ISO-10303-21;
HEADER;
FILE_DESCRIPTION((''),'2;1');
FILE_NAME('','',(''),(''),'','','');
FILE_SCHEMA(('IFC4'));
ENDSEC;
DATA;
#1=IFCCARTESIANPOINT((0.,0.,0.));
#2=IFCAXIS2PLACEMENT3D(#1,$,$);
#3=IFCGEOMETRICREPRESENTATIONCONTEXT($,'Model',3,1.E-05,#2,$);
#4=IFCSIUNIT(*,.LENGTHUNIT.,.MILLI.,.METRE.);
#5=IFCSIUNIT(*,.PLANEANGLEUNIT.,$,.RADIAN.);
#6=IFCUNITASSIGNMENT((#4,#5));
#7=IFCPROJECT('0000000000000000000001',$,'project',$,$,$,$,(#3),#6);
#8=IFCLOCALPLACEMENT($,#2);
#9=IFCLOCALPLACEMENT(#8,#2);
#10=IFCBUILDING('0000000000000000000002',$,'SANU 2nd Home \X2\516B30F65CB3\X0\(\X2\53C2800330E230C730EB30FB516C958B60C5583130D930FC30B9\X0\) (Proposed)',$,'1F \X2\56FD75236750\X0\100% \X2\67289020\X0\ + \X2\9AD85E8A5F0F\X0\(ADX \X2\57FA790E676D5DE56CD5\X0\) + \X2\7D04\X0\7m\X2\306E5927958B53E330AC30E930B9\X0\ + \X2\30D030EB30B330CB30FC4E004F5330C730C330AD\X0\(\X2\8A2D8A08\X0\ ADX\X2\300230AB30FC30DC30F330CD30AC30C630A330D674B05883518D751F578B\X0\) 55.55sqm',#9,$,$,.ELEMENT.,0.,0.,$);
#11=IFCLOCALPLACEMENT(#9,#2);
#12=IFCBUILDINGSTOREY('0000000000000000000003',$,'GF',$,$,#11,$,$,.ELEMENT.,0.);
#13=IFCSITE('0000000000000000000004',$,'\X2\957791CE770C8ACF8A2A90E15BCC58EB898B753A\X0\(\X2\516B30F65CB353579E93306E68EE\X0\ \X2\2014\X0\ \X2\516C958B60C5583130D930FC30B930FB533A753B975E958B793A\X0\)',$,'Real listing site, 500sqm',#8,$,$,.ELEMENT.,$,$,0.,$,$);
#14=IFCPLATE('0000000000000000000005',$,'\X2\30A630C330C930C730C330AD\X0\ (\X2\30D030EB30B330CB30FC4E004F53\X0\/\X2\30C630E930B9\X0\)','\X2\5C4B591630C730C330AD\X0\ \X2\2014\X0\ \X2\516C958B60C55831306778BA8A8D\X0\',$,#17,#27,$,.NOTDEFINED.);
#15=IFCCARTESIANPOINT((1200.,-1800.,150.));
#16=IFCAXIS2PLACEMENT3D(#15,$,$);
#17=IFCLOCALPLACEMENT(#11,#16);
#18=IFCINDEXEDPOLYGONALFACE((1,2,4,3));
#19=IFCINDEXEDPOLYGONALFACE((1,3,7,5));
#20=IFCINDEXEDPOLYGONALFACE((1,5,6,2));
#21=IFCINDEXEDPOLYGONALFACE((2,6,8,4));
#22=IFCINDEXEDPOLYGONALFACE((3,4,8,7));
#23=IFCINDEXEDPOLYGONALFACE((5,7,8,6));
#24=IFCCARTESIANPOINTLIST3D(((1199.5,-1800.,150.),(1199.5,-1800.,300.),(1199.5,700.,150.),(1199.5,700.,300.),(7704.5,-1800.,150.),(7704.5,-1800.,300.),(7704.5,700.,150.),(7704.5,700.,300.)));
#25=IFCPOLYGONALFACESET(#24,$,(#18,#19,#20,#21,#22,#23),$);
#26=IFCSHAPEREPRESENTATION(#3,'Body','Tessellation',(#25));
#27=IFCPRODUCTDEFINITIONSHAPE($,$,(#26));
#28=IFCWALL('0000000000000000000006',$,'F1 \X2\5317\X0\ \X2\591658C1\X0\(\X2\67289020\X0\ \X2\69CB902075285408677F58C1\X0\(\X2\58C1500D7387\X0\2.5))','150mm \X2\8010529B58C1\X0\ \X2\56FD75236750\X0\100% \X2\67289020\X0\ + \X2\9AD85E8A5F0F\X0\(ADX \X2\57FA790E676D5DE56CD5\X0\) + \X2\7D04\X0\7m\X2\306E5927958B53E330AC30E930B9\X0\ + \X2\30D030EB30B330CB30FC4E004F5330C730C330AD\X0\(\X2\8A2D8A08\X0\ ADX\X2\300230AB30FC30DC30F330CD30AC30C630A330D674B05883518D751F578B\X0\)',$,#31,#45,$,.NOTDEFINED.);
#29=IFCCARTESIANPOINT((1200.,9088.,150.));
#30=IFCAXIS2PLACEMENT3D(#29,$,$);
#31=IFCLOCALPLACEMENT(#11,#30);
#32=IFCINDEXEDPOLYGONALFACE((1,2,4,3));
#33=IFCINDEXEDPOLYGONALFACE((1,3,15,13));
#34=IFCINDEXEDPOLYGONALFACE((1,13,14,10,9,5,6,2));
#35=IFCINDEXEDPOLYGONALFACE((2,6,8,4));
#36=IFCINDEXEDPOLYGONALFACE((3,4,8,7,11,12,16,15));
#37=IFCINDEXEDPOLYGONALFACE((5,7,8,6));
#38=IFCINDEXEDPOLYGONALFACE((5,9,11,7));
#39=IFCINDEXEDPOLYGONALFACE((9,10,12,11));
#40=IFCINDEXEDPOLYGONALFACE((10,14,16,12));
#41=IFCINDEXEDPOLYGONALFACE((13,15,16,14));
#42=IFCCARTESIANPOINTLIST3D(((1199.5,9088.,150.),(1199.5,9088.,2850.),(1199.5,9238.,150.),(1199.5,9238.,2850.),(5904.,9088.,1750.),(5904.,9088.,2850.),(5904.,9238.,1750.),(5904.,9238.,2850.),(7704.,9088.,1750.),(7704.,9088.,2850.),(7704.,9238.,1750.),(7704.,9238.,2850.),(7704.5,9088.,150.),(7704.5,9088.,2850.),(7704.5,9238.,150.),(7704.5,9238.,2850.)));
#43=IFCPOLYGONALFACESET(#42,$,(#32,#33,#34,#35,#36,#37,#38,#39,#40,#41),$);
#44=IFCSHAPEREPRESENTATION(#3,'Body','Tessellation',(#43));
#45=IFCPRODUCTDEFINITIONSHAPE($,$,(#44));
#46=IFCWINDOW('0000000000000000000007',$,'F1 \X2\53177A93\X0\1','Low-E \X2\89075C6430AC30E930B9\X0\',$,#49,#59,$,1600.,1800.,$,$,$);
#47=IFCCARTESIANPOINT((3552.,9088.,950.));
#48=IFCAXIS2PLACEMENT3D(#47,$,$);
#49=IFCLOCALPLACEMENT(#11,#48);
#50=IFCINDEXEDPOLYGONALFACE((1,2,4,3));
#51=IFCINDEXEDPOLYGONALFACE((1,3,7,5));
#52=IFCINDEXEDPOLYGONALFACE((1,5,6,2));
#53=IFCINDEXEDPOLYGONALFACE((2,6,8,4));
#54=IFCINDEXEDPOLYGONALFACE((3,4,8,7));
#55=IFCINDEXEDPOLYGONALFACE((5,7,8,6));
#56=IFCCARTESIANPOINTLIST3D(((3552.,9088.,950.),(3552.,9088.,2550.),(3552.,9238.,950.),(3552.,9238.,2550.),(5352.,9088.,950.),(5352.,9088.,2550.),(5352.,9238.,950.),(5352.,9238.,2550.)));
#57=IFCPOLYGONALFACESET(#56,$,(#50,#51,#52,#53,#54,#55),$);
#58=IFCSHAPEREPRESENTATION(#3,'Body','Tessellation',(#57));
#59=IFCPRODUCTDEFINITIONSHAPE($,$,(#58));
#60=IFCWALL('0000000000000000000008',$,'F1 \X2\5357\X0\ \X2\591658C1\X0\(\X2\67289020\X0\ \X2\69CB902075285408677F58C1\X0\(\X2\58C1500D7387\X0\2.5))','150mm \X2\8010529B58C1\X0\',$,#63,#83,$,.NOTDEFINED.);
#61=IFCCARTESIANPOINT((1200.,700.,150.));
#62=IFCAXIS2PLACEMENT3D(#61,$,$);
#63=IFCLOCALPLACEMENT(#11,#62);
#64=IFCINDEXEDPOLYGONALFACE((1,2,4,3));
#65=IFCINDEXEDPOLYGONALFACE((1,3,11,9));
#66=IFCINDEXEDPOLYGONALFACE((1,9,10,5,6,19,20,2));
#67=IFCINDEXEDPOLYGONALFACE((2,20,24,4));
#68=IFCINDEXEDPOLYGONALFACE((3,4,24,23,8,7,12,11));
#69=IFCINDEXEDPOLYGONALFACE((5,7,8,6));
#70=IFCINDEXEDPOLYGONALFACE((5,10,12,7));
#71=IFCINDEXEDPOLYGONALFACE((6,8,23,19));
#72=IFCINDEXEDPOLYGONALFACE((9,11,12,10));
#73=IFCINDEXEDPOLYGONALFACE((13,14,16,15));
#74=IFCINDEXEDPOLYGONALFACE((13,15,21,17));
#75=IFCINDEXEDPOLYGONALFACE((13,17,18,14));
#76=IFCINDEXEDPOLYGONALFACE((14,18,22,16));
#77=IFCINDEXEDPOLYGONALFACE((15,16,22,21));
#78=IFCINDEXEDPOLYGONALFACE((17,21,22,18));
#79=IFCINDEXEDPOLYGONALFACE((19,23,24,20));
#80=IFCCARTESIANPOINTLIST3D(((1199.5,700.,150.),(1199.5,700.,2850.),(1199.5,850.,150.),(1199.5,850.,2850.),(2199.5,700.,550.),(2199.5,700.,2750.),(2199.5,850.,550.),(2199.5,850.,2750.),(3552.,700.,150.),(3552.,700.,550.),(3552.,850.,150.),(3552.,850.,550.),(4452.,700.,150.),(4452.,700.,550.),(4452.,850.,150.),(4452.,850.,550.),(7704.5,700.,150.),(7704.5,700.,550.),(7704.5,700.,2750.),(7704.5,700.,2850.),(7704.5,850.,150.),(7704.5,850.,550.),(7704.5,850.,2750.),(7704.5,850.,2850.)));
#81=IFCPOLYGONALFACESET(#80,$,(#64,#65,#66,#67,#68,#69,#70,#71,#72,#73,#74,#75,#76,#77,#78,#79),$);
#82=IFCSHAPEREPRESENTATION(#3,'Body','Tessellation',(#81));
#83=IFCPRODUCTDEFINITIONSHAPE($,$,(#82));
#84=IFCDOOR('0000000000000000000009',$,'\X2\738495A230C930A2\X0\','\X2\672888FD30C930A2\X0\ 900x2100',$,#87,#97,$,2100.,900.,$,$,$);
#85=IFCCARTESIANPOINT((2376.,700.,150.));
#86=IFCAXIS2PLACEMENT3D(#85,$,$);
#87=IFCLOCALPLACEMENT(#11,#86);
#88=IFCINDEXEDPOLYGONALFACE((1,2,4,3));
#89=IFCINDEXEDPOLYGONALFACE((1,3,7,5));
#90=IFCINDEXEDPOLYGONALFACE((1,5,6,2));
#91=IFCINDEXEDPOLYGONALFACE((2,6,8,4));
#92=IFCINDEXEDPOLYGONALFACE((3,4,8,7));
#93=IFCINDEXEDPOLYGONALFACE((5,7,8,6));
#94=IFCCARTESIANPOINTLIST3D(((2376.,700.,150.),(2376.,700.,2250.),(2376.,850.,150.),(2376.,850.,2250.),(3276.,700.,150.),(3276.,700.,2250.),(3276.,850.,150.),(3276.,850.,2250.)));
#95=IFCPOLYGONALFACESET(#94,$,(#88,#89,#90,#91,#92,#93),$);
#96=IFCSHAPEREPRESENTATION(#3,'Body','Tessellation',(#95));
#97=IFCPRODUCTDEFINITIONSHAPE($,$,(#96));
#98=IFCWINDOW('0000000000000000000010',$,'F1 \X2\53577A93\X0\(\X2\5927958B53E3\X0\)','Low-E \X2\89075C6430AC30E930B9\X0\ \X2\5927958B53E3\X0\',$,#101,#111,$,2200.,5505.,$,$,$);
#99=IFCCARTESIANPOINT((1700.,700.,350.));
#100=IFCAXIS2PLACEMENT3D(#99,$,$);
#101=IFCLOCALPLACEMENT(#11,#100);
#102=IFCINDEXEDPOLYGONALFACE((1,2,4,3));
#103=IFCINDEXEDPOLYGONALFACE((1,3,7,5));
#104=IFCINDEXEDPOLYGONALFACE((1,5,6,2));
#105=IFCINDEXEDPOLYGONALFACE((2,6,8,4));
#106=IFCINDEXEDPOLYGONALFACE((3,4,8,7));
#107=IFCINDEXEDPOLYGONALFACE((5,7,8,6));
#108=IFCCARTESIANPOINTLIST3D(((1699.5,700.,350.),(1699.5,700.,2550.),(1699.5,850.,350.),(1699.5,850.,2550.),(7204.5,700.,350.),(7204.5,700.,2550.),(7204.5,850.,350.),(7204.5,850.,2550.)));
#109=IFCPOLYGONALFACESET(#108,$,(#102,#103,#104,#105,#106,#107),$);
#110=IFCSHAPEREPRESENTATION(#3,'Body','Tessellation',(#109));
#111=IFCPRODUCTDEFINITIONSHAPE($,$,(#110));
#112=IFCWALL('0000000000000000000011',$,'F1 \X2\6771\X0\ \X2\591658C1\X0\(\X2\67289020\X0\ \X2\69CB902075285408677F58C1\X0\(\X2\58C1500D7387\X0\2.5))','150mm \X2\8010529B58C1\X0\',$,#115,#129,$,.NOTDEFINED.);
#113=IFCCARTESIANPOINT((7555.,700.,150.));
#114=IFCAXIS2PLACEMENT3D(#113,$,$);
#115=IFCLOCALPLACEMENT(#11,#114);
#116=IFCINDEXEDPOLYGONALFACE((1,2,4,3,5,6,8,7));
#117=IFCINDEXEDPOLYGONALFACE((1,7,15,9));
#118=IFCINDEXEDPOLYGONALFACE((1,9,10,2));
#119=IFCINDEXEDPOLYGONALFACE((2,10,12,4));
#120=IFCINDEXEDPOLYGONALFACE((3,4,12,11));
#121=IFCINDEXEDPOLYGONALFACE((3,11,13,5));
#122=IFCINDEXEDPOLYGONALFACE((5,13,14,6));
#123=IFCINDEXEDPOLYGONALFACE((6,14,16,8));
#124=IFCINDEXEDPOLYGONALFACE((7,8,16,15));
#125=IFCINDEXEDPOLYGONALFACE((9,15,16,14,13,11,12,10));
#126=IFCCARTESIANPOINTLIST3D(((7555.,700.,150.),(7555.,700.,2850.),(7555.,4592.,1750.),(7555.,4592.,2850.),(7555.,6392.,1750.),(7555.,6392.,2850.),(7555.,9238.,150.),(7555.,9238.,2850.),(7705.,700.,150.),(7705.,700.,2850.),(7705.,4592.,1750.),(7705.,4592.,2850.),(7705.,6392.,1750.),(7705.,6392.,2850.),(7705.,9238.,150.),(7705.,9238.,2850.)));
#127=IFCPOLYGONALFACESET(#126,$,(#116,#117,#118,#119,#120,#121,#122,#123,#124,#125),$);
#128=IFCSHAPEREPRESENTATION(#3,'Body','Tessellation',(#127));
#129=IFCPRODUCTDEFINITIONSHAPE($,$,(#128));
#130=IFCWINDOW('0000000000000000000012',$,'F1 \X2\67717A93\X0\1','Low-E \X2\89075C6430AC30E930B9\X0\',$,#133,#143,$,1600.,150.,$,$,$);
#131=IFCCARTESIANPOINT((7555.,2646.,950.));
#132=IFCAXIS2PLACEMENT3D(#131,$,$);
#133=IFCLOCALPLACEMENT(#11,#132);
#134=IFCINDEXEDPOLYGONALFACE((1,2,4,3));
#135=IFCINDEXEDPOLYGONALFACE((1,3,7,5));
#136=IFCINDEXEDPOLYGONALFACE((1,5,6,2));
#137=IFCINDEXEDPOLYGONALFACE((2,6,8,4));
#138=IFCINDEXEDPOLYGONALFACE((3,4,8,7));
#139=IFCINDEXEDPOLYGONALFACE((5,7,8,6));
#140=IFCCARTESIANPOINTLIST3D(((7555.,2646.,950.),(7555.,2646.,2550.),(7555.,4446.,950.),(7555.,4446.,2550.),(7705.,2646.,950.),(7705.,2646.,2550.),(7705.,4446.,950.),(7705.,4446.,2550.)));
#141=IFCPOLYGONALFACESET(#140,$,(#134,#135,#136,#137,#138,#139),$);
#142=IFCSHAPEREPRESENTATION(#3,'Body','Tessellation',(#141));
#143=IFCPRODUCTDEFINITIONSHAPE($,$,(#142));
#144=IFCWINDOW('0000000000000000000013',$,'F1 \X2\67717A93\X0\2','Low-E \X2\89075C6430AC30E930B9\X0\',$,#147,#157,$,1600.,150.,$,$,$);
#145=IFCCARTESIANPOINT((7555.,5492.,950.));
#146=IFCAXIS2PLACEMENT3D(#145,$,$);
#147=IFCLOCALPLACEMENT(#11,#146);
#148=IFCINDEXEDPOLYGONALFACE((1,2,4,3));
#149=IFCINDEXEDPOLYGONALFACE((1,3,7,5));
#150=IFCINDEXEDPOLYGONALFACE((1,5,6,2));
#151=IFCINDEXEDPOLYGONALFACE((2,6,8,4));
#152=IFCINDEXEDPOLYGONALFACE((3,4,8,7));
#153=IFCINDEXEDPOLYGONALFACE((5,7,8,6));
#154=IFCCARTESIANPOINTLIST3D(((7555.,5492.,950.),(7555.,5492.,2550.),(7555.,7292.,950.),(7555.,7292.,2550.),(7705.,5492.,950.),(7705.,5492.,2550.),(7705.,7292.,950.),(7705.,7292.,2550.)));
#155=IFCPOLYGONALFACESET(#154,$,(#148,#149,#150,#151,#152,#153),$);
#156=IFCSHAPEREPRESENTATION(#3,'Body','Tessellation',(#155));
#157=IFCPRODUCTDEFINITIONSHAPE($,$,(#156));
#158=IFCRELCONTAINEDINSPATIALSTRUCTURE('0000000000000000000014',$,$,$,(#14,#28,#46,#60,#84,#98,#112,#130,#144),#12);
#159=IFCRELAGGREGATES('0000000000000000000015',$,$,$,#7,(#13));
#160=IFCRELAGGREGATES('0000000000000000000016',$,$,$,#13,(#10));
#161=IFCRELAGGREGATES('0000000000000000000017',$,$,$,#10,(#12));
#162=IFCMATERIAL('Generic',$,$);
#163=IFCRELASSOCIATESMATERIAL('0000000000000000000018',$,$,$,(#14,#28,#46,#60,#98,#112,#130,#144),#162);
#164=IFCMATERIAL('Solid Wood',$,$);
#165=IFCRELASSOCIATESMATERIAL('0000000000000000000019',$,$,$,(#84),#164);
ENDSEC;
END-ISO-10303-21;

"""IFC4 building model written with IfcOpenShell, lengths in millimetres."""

from ifc_helpers import new_model, si_unit, frame, frame_2d, origin, place, context, project, spatial, rectangle, extrude, material, element, fill, save


model = new_model("IFC4")

# Units and contexts
model_context = context("Model", 3, precision=1e-05, world=origin())
ifc_project = project(units=[si_unit("LENGTHUNIT", "METRE", prefix="MILLI"), si_unit("PLANEANGLEUNIT", "RADIAN")], contexts=[model_context])

# Site, building, storey
site_placement = place(None, origin())
site = spatial("IfcSite", under=ifc_project, at=site_placement, Name="長野県諏訪郡富士見町(八ヶ岳南麓の森 — 公開情報ベース・区画非開示)", ObjectType="Real listing site, 500sqm", CompositionType="ELEMENT", RefElevation=0.0)
building_placement = place(site_placement, origin())
building = spatial("IfcBuilding", under=site, at=building_placement, Name="SANU 2nd Home 八ヶ岳(参考モデル・公開情報ベース) (Proposed)", ObjectType="1F 国産材100% 木造 + 高床式(ADX 基礎杭工法) + 約7mの大開口ガラス + バルコニー一体デッキ(設計 ADX。カーボンネガティブ環境再生型) 55.55sqm", CompositionType="ELEMENT", ElevationOfRefHeight=0.0, ElevationOfTerrain=0.0)
storey_placement = place(building_placement, origin())
storey = spatial("IfcBuildingStorey", under=building, at=storey_placement, Name="GF", CompositionType="ELEMENT", Elevation=0.0)

# Shared definitions
ifc_material_1 = material(Name="Generic")

# Plate
plate_placement = place(storey_placement, frame((1200.0, -1800.0, 150.0)))
element("IfcPlate", 1, at=plate_placement, inside=storey, material=ifc_material_1, Name="ウッドデッキ (バルコニー一体/テラス)", Description="屋外デッキ — 公開情報で確認", PredefinedType="NOTDEFINED", context=model_context, shape_type="SweptSolid", body=[
    extrude(rectangle(XDim=6505.0, YDim=2500.0, at=frame_2d((3252.0, 1250.0))), frame((1200.0, -1800.0, 150.0)), (0.0, 0.0, 1.0), 150.0),
])

# Wall, opening, window
wall_1_placement = place(storey_placement, frame((1200.0, 9088.0, 150.0)))
wall_1 = element("IfcWall", 2, at=wall_1_placement, inside=storey, material=ifc_material_1, Name="F1 北 外壁(木造 構造用合板壁(壁倍率2.5))", Description="150mm 耐力壁 国産材100% 木造 + 高床式(ADX 基礎杭工法) + 約7mの大開口ガラス + バルコニー一体デッキ(設計 ADX。カーボンネガティブ環境再生型)", PredefinedType="NOTDEFINED", context=model_context, shape_type="SweptSolid", body=[
    extrude(rectangle(XDim=6505.0, YDim=150.0, at=frame_2d((3252.0, 75.0))), frame((1200.0, 9088.0, 150.0)), (0.0, 0.0, 1.0), 2700.0),
])
opening_1_placement = place(storey_placement, frame((3552.0, 9088.0, 950.0)))
opening_1 = element("IfcOpeningElement", 3, at=opening_1_placement, cuts=wall_1, PredefinedType="NOTDEFINED", context=model_context, shape_type="SweptSolid", body=[
    extrude(rectangle(XDim=1800.0, YDim=150.0, at=frame_2d((900.0, 75.0))), frame((3552.0, 9088.0, 950.0)), (0.0, 0.0, 1.0), 1600.0),
])
window_1_placement = place(storey_placement, frame((3552.0, 9088.0, 950.0)))
window_1 = element("IfcWindow", 4, at=window_1_placement, inside=storey, material=ifc_material_1, Name="F1 北窓1", Description="Low-E 複層ガラス", OverallHeight=1600.0, OverallWidth=1800.0, context=model_context, shape_type="SweptSolid", body=[
    extrude(rectangle(XDim=1800.0, YDim=150.0, at=frame_2d((900.0, 75.0))), frame((3552.0, 9088.0, 950.0)), (0.0, 0.0, 1.0), 1600.0),
])
fill(opening_1, window_1)

# Wall, openings, door, window
wall_2_placement = place(storey_placement, frame((1200.0, 700.0, 150.0)))
wall_2 = element("IfcWall", 5, at=wall_2_placement, inside=storey, material=ifc_material_1, Name="F1 南 外壁(木造 構造用合板壁(壁倍率2.5))", Description="150mm 耐力壁", PredefinedType="NOTDEFINED", context=model_context, shape_type="SweptSolid", body=[
    extrude(rectangle(XDim=6505.0, YDim=150.0, at=frame_2d((3252.0, 75.0))), frame((1200.0, 700.0, 150.0)), (0.0, 0.0, 1.0), 2700.0),
])
opening_2_placement = place(storey_placement, frame((2376.0, 700.0, 150.0)))
opening_2 = element("IfcOpeningElement", 6, at=opening_2_placement, cuts=wall_2, PredefinedType="NOTDEFINED", context=model_context, shape_type="SweptSolid", body=[
    extrude(rectangle(XDim=900.0, YDim=150.0, at=frame_2d((450.0, 75.0))), frame((2376.0, 700.0, 150.0)), (0.0, 0.0, 1.0), 2100.0),
])
opening_3_placement = place(storey_placement, frame((1700.0, 700.0, 350.0)))
opening_3 = element("IfcOpeningElement", 7, at=opening_3_placement, cuts=wall_2, PredefinedType="NOTDEFINED", context=model_context, shape_type="SweptSolid", body=[
    extrude(rectangle(XDim=5505.0, YDim=150.0, at=frame_2d((2752.0, 75.0))), frame((1700.0, 700.0, 350.0)), (0.0, 0.0, 1.0), 2200.0),
])
ifc_material_2 = material(Name="Solid Wood")
door_placement = place(storey_placement, frame((2376.0, 700.0, 150.0)))
door = element("IfcDoor", 8, at=door_placement, inside=storey, material=ifc_material_2, Name="玄関ドア", Description="木製ドア 900x2100", OverallHeight=2100.0, OverallWidth=900.0, context=model_context, shape_type="SweptSolid", body=[
    extrude(rectangle(XDim=900.0, YDim=150.0, at=frame_2d((450.0, 75.0))), frame((2376.0, 700.0, 150.0)), (0.0, 0.0, 1.0), 2100.0),
])
fill(opening_2, door)
window_2_placement = place(storey_placement, frame((1700.0, 700.0, 350.0)))
window_2 = element("IfcWindow", 9, at=window_2_placement, inside=storey, material=ifc_material_1, Name="F1 南窓(大開口)", Description="Low-E 複層ガラス 大開口", OverallHeight=2200.0, OverallWidth=5505.0, context=model_context, shape_type="SweptSolid", body=[
    extrude(rectangle(XDim=5505.0, YDim=150.0, at=frame_2d((2752.0, 75.0))), frame((1700.0, 700.0, 350.0)), (0.0, 0.0, 1.0), 2200.0),
])
fill(opening_3, window_2)

# Wall, openings, windows
wall_3_placement = place(storey_placement, frame((7555.0, 700.0, 150.0)))
wall_3 = element("IfcWall", 10, at=wall_3_placement, inside=storey, material=ifc_material_1, Name="F1 東 外壁(木造 構造用合板壁(壁倍率2.5))", Description="150mm 耐力壁", PredefinedType="NOTDEFINED", context=model_context, shape_type="SweptSolid", body=[
    extrude(rectangle(XDim=150.0, YDim=8538.0, at=frame_2d((75.0, 4269.0))), frame((7555.0, 700.0, 150.0)), (0.0, 0.0, 1.0), 2700.0),
])
opening_4_placement = place(storey_placement, frame((7555.0, 2646.0, 950.0)))
opening_4 = element("IfcOpeningElement", 11, at=opening_4_placement, cuts=wall_3, PredefinedType="NOTDEFINED", context=model_context, shape_type="SweptSolid", body=[
    extrude(rectangle(XDim=150.0, YDim=1800.0, at=frame_2d((75.0, 900.0))), frame((7555.0, 2646.0, 950.0)), (0.0, 0.0, 1.0), 1600.0),
])
opening_5_placement = place(storey_placement, frame((7555.0, 5492.0, 950.0)))
opening_5 = element("IfcOpeningElement", 12, at=opening_5_placement, cuts=wall_3, PredefinedType="NOTDEFINED", context=model_context, shape_type="SweptSolid", body=[
    extrude(rectangle(XDim=150.0, YDim=1800.0, at=frame_2d((75.0, 900.0))), frame((7555.0, 5492.0, 950.0)), (0.0, 0.0, 1.0), 1600.0),
])
window_3_placement = place(storey_placement, frame((7555.0, 2646.0, 950.0)))
window_3 = element("IfcWindow", 13, at=window_3_placement, inside=storey, material=ifc_material_1, Name="F1 東窓1", Description="Low-E 複層ガラス", OverallHeight=1600.0, OverallWidth=150.0, context=model_context, shape_type="SweptSolid", body=[
    extrude(rectangle(XDim=150.0, YDim=1800.0, at=frame_2d((75.0, 900.0))), frame((7555.0, 2646.0, 950.0)), (0.0, 0.0, 1.0), 1600.0),
])
fill(opening_4, window_3)
window_4_placement = place(storey_placement, frame((7555.0, 5492.0, 950.0)))
window_4 = element("IfcWindow", 14, at=window_4_placement, inside=storey, material=ifc_material_1, Name="F1 東窓2", Description="Low-E 複層ガラス", OverallHeight=1600.0, OverallWidth=150.0, context=model_context, shape_type="SweptSolid", body=[
    extrude(rectangle(XDim=150.0, YDim=1800.0, at=frame_2d((75.0, 900.0))), frame((7555.0, 5492.0, 950.0)), (0.0, 0.0, 1.0), 1600.0),
])
fill(opening_5, window_4)

save(model, "model.ifc")
